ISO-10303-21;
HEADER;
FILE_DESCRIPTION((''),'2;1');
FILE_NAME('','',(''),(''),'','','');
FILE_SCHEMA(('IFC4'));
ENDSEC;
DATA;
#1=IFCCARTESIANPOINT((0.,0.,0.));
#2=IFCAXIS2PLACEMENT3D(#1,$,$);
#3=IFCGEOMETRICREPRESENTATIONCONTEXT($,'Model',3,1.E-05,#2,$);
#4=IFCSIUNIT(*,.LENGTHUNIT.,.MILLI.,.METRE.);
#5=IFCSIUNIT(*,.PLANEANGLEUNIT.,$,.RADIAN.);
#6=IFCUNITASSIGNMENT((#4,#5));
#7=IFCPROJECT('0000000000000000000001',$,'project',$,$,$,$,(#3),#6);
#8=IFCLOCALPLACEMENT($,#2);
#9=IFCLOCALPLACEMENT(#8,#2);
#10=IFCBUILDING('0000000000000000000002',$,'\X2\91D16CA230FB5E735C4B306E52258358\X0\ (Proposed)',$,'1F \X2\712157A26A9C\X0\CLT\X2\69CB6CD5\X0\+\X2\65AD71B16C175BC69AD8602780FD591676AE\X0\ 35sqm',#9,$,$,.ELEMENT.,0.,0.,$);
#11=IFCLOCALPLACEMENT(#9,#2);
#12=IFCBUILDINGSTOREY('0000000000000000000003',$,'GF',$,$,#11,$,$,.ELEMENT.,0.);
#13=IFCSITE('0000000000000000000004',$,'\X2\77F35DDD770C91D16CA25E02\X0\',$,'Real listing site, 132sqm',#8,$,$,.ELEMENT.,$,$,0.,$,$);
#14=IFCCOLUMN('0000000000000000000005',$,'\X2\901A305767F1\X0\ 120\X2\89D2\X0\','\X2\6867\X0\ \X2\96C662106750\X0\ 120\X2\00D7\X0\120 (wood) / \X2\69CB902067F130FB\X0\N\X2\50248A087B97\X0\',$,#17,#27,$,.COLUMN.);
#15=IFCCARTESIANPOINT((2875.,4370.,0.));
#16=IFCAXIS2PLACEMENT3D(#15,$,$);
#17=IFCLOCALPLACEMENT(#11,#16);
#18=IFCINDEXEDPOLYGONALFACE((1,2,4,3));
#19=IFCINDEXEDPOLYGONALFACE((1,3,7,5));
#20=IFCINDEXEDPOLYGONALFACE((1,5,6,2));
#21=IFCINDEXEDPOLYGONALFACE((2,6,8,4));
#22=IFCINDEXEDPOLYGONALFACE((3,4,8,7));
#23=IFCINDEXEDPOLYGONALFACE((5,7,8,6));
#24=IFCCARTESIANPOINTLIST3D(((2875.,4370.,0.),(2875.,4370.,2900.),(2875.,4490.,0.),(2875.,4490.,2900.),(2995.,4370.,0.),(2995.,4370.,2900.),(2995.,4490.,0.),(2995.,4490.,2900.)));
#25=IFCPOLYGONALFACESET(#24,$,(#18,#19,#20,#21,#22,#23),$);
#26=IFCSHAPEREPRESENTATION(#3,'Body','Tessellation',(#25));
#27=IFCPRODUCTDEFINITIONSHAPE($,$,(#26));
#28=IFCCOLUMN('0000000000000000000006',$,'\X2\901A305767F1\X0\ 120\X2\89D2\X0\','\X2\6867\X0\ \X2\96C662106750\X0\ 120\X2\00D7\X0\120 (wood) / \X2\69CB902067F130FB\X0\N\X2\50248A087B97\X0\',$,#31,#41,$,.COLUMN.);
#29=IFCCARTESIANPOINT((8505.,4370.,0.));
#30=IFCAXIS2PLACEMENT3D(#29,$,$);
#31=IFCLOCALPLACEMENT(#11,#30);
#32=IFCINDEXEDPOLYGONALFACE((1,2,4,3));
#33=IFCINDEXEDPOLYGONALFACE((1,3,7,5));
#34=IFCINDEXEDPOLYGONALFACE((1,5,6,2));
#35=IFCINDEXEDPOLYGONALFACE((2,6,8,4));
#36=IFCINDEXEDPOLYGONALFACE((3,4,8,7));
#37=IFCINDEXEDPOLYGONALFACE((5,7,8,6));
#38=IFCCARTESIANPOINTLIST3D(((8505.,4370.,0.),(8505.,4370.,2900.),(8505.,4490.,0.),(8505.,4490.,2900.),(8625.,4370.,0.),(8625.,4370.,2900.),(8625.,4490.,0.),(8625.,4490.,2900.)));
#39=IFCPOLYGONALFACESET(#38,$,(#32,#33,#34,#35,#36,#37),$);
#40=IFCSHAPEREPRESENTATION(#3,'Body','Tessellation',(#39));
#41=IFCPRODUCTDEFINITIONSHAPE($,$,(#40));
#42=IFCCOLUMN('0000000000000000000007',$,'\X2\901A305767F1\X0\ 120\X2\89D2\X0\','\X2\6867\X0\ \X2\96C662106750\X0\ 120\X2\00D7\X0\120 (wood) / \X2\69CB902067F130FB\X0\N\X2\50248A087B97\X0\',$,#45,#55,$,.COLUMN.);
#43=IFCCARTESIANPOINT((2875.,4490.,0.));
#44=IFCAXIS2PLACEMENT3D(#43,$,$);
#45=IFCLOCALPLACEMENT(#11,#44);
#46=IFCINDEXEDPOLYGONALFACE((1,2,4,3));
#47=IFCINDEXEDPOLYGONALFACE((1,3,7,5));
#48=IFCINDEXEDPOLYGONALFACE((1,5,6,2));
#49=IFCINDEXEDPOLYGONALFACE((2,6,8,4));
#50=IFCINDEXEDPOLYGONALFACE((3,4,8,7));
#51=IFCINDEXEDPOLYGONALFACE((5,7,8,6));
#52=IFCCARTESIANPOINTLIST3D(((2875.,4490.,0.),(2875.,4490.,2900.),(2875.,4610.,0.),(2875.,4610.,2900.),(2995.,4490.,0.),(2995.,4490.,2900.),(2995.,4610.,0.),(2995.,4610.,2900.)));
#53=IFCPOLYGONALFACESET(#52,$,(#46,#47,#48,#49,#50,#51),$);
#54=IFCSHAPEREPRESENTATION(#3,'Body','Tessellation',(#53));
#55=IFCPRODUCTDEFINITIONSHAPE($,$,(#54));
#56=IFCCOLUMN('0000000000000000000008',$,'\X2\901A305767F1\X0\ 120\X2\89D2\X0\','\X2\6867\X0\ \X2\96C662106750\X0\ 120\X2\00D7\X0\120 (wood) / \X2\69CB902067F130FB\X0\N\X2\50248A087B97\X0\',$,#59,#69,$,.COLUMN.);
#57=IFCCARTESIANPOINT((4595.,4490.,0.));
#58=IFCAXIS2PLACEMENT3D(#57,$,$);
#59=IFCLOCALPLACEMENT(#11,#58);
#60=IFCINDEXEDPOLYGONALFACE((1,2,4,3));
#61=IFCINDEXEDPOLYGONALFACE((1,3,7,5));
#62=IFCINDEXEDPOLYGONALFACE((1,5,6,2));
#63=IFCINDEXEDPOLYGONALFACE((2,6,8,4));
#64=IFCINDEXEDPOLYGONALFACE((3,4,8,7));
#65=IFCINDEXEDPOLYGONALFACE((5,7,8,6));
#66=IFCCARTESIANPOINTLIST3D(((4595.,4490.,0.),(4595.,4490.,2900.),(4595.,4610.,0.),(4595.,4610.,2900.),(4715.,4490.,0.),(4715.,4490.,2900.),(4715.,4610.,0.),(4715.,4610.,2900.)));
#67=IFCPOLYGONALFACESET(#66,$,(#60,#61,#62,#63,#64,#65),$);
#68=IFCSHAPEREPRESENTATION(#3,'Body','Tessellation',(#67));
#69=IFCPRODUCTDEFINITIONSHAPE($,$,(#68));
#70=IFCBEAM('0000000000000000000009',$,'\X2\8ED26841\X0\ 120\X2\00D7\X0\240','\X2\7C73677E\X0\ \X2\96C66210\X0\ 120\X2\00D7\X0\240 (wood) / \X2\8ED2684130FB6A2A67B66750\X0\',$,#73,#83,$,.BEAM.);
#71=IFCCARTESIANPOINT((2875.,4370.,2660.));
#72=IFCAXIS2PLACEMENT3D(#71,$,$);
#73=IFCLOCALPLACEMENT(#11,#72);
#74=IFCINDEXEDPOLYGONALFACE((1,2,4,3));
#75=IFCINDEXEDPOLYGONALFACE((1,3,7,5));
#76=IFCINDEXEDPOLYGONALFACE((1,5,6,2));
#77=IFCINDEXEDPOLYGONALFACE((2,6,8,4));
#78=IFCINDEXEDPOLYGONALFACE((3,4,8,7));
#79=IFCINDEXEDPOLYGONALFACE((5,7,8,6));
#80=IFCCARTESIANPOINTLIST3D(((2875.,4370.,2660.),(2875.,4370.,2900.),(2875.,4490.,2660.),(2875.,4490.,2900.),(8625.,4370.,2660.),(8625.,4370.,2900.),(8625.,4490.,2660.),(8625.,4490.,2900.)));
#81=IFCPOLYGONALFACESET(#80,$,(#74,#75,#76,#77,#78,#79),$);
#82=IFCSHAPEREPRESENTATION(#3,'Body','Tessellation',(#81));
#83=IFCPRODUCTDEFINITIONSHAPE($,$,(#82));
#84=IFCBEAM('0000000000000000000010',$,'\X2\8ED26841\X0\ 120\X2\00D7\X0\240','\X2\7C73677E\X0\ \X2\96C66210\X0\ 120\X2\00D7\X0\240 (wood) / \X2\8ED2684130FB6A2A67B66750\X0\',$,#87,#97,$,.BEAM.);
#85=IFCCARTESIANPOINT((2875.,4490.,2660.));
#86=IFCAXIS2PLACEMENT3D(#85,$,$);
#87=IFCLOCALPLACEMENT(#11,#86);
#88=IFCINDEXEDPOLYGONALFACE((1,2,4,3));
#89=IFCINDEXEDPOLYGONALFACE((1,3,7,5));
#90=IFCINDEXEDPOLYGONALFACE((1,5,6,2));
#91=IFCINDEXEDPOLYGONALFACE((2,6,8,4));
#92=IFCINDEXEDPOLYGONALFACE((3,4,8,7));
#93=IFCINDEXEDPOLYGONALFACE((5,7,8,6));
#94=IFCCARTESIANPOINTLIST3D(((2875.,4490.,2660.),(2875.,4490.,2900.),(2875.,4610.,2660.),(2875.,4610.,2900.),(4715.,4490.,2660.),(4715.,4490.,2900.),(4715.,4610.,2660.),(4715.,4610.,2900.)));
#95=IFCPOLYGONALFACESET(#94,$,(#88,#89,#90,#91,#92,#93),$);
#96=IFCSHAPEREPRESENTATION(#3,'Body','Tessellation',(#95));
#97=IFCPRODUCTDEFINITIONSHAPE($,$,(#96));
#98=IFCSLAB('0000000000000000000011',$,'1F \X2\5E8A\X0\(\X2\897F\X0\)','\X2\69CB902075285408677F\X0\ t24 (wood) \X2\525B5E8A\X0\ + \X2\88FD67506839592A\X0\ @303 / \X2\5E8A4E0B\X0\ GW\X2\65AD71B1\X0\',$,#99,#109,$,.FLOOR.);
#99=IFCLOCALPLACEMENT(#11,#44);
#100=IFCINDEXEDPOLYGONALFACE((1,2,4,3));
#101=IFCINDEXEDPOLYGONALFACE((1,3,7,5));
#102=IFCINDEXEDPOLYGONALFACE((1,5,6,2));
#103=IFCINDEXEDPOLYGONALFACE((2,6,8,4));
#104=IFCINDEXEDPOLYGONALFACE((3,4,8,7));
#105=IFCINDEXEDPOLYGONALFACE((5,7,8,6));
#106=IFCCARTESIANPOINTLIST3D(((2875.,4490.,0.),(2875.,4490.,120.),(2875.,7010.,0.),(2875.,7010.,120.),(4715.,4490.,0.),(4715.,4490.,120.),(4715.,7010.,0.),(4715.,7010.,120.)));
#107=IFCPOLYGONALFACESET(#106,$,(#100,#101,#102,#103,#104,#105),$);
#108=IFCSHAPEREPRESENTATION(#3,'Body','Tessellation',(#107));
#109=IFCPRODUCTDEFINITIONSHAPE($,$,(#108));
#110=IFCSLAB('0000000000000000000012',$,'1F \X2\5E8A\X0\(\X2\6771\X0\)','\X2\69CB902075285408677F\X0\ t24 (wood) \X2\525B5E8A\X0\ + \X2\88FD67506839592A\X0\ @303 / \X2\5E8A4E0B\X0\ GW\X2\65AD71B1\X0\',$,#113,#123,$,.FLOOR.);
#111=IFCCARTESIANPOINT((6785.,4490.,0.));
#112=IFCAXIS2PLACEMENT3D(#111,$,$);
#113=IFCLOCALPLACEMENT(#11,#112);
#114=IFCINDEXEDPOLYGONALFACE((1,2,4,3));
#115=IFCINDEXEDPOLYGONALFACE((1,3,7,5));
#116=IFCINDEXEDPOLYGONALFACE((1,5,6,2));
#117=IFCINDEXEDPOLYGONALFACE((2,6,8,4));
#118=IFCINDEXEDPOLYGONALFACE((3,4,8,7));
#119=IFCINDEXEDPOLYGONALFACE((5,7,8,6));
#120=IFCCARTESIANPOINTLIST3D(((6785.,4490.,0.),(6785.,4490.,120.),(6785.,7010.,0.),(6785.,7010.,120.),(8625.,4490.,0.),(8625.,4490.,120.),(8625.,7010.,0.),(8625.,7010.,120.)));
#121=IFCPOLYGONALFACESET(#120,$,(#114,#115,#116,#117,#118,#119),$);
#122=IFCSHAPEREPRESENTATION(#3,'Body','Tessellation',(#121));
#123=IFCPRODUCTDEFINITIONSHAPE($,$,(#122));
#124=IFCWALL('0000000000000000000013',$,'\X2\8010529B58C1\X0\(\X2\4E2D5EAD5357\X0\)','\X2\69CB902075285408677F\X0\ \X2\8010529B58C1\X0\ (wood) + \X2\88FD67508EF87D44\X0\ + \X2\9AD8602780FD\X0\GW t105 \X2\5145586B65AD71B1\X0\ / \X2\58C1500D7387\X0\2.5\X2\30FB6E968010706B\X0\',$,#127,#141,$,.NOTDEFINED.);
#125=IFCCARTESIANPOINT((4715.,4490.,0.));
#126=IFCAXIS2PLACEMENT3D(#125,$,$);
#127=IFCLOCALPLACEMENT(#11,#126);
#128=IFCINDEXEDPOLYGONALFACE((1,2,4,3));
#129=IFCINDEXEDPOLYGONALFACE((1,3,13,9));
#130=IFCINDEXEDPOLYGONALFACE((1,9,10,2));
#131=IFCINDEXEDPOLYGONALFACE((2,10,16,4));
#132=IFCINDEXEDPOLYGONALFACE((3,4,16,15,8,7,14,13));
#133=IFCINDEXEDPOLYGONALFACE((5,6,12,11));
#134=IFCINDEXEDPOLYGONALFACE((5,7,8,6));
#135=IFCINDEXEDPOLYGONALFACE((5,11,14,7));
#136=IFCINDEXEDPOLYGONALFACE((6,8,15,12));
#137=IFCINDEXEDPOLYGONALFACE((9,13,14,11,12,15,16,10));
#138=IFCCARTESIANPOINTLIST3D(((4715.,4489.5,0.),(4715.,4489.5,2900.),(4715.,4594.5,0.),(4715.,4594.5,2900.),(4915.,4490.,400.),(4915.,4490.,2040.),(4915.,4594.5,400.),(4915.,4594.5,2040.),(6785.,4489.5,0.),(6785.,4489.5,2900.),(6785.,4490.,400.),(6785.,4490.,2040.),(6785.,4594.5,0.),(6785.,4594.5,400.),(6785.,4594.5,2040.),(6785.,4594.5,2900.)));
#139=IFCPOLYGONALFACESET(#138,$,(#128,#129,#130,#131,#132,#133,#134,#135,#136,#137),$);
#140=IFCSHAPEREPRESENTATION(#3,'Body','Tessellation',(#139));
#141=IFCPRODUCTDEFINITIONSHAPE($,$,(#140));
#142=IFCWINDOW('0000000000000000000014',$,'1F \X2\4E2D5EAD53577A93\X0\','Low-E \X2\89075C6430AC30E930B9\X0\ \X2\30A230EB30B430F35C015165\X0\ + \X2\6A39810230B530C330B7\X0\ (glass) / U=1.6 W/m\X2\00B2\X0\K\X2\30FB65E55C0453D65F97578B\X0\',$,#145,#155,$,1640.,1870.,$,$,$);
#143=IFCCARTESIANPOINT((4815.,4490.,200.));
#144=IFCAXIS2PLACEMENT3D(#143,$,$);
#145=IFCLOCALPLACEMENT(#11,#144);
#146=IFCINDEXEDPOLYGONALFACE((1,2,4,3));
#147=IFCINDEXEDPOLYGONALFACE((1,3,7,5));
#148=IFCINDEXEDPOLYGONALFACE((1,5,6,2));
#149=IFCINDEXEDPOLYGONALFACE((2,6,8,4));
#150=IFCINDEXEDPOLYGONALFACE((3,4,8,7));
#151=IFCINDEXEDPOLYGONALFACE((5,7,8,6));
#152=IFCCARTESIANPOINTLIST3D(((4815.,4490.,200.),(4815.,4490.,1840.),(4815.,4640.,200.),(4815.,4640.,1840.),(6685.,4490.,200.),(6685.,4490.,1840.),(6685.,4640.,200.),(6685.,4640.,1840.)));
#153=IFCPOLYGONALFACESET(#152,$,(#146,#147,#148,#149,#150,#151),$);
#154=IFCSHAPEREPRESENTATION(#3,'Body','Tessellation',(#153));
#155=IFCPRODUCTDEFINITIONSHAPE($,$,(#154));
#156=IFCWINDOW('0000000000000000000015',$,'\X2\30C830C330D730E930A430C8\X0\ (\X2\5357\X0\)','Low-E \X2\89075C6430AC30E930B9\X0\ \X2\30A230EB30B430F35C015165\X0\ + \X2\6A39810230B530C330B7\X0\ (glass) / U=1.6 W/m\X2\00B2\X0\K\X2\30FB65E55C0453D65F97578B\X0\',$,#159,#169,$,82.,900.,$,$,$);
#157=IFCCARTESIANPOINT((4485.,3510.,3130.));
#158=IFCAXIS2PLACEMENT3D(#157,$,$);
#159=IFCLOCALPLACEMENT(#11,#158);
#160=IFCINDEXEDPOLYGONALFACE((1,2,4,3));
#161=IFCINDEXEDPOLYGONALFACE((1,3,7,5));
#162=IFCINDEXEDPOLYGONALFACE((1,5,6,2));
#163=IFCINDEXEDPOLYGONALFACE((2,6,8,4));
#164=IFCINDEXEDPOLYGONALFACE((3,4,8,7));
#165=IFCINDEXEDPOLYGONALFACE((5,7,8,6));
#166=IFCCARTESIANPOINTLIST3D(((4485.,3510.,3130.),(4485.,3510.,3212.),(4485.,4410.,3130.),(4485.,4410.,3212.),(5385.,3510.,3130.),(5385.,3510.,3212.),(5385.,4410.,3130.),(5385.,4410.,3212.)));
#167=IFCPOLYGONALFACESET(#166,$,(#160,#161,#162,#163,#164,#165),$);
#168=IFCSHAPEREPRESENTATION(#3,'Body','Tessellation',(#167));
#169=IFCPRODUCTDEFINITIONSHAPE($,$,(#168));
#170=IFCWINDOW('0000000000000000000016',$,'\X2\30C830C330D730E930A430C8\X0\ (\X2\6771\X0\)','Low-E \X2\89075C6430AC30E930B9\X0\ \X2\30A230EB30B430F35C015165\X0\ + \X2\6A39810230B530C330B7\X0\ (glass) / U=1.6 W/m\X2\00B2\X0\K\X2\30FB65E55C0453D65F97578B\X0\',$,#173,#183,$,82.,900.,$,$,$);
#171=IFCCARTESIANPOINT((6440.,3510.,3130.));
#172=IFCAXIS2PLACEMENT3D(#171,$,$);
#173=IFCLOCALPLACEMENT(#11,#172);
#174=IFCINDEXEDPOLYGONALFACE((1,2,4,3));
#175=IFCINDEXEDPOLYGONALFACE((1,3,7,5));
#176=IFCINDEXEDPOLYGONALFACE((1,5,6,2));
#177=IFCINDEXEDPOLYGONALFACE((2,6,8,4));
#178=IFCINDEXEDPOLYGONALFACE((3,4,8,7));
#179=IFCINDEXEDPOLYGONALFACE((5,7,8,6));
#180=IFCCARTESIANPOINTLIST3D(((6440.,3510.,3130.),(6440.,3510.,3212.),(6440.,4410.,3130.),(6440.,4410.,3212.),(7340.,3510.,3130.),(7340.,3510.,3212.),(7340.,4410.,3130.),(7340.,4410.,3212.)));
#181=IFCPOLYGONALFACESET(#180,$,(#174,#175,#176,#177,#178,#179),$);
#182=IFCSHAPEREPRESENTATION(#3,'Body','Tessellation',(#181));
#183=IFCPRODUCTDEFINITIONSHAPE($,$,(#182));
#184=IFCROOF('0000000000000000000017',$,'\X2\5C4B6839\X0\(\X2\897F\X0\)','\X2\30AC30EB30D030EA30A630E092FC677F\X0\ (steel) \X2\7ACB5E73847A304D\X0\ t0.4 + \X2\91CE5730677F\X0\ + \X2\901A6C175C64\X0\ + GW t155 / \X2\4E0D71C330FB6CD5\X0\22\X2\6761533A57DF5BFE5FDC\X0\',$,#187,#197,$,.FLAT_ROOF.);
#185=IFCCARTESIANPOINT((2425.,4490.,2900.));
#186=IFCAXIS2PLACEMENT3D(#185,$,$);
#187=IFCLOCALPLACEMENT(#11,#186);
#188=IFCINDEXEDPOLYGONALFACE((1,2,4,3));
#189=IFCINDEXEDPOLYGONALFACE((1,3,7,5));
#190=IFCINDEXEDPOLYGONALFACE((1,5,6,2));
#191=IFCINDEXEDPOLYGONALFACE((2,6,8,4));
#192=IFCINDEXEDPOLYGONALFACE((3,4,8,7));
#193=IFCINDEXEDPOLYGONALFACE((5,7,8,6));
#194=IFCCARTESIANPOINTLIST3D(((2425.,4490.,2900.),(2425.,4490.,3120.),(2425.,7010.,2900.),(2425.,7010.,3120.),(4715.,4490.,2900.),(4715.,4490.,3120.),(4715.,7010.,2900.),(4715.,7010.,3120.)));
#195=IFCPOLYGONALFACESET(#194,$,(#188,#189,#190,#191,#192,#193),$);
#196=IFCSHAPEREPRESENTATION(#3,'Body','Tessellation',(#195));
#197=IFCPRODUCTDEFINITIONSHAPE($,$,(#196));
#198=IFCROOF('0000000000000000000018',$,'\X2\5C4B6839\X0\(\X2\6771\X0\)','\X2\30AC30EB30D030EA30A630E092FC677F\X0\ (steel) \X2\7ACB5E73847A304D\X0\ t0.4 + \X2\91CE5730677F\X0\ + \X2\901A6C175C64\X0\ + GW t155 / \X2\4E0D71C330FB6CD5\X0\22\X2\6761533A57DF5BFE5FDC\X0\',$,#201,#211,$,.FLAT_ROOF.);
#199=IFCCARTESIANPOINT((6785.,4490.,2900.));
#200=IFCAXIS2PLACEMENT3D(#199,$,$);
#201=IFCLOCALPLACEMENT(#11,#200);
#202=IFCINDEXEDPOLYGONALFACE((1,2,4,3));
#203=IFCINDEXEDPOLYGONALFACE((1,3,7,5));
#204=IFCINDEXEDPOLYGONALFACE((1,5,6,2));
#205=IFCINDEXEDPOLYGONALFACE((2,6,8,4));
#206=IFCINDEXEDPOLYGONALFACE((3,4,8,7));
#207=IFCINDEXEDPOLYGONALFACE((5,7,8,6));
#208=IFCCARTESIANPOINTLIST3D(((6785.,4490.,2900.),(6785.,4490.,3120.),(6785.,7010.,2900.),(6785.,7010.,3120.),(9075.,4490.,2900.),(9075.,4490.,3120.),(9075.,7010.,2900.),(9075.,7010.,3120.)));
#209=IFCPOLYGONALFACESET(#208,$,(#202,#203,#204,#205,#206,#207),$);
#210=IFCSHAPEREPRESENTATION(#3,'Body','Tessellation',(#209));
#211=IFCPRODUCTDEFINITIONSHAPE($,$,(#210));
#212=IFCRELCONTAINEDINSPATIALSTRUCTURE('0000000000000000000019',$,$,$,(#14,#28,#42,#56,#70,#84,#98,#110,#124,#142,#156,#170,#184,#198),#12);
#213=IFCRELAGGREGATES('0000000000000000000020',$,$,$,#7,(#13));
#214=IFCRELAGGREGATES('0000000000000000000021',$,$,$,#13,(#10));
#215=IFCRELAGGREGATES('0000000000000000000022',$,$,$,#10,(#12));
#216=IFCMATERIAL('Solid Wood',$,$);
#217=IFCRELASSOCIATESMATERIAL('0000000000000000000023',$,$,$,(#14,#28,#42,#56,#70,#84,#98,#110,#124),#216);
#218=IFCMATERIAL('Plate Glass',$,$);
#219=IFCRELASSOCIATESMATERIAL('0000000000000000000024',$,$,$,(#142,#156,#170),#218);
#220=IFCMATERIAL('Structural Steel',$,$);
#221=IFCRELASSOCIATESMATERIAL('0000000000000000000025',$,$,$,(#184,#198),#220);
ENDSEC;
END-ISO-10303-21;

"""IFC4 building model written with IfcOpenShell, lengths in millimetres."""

from ifc_helpers import new_model, si_unit, frame, frame_2d, origin, place, context, project, spatial, rectangle, extrude, material, element, fill, save


model = new_model("IFC4")

# Units and contexts
model_context = context("Model", 3, precision=1e-05, world=origin())
ifc_project = project(units=[si_unit("LENGTHUNIT", "METRE", prefix="MILLI"), si_unit("PLANEANGLEUNIT", "RADIAN")], contexts=[model_context])

# Site, building, storey
site_placement = place(None, origin())
site = spatial("IfcSite", under=ifc_project, at=site_placement, Name="石川県金沢市", ObjectType="Real listing site, 132sqm", CompositionType="ELEMENT", RefElevation=0.0)
building_placement = place(site_placement, origin())
building = spatial("IfcBuilding", under=site, at=building_placement, Name="金沢・平屋の別荘 (Proposed)", ObjectType="1F 無垢檜CLT構法+断熱気密高性能外皮 35sqm", CompositionType="ELEMENT", ElevationOfRefHeight=0.0, ElevationOfTerrain=0.0)
storey_placement = place(building_placement, origin())
storey = spatial("IfcBuildingStorey", under=building, at=storey_placement, Name="GF", CompositionType="ELEMENT", Elevation=0.0)

# Columns
ifc_material_1 = material(Name="Solid Wood")
column_1_placement = place(storey_placement, frame((2875.0, 4370.0, 0.0)))
element("IfcColumn", 1, at=column_1_placement, inside=storey, material=ifc_material_1, Name="通し柱 120角", Description="桧 集成材 120×120 (wood) / 構造柱・N値計算", PredefinedType="COLUMN", context=model_context, shape_type="SweptSolid", body=[
    extrude(rectangle(XDim=120.0, YDim=120.0, at=frame_2d((60.0, 60.0))), frame((2875.0, 4370.0, 0.0)), (0.0, 0.0, 1.0), 2900.0),
])
column_2_placement = place(storey_placement, frame((8505.0, 4370.0, 0.0)))
element("IfcColumn", 2, at=column_2_placement, inside=storey, material=ifc_material_1, Name="通し柱 120角", Description="桧 集成材 120×120 (wood) / 構造柱・N値計算", PredefinedType="COLUMN", context=model_context, shape_type="SweptSolid", body=[
    extrude(rectangle(XDim=120.0, YDim=120.0, at=frame_2d((60.0, 60.0))), frame((8505.0, 4370.0, 0.0)), (0.0, 0.0, 1.0), 2900.0),
])
column_3_placement = place(storey_placement, frame((2875.0, 4490.0, 0.0)))
element("IfcColumn", 3, at=column_3_placement, inside=storey, material=ifc_material_1, Name="通し柱 120角", Description="桧 集成材 120×120 (wood) / 構造柱・N値計算", PredefinedType="COLUMN", context=model_context, shape_type="SweptSolid", body=[
    extrude(rectangle(XDim=120.0, YDim=120.0, at=frame_2d((60.0, 60.0))), frame((2875.0, 4490.0, 0.0)), (0.0, 0.0, 1.0), 2900.0),
])
column_4_placement = place(storey_placement, frame((4595.0, 4490.0, 0.0)))
element("IfcColumn", 4, at=column_4_placement, inside=storey, material=ifc_material_1, Name="通し柱 120角", Description="桧 集成材 120×120 (wood) / 構造柱・N値計算", PredefinedType="COLUMN", context=model_context, shape_type="SweptSolid", body=[
    extrude(rectangle(XDim=120.0, YDim=120.0, at=frame_2d((60.0, 60.0))), frame((4595.0, 4490.0, 0.0)), (0.0, 0.0, 1.0), 2900.0),
])

# Beams
beam_1_placement = place(storey_placement, frame((2875.0, 4370.0, 2660.0)))
element("IfcBeam", 5, at=beam_1_placement, inside=storey, material=ifc_material_1, Name="軒桁 120×240", Description="米松 集成 120×240 (wood) / 軒桁・横架材", PredefinedType="BEAM", context=model_context, shape_type="SweptSolid", body=[
    extrude(rectangle(XDim=5750.0, YDim=120.0, at=frame_2d((2875.0, 60.0))), frame((2875.0, 4370.0, 2660.0)), (0.0, 0.0, 1.0), 240.0),
])
beam_2_placement = place(storey_placement, frame((2875.0, 4490.0, 2660.0)))
element("IfcBeam", 6, at=beam_2_placement, inside=storey, material=ifc_material_1, Name="軒桁 120×240", Description="米松 集成 120×240 (wood) / 軒桁・横架材", PredefinedType="BEAM", context=model_context, shape_type="SweptSolid", body=[
    extrude(rectangle(XDim=1840.0, YDim=120.0, at=frame_2d((920.0, 60.0))), frame((2875.0, 4490.0, 2660.0)), (0.0, 0.0, 1.0), 240.0),
])

# Slabs
slab_1_placement = place(storey_placement, frame((2875.0, 4490.0, 0.0)))
element("IfcSlab", 7, at=slab_1_placement, inside=storey, material=ifc_material_1, Name="1F 床(西)", Description="構造用合板 t24 (wood) 剛床 + 製材根太 @303 / 床下 GW断熱", PredefinedType="FLOOR", context=model_context, shape_type="SweptSolid", body=[
    extrude(rectangle(XDim=1840.0, YDim=2520.0, at=frame_2d((920.0, 1260.0))), frame((2875.0, 4490.0, 0.0)), (0.0, 0.0, 1.0), 120.0),
])
slab_2_placement = place(storey_placement, frame((6785.0, 4490.0, 0.0)))
element("IfcSlab", 8, at=slab_2_placement, inside=storey, material=ifc_material_1, Name="1F 床(東)", Description="構造用合板 t24 (wood) 剛床 + 製材根太 @303 / 床下 GW断熱", PredefinedType="FLOOR", context=model_context, shape_type="SweptSolid", body=[
    extrude(rectangle(XDim=1840.0, YDim=2520.0, at=frame_2d((920.0, 1260.0))), frame((6785.0, 4490.0, 0.0)), (0.0, 0.0, 1.0), 120.0),
])

# Wall, opening, window
wall_1_placement = place(storey_placement, frame((4715.0, 4490.0, 0.0)))
wall_1 = element("IfcWall", 9, at=wall_1_placement, inside=storey, material=ifc_material_1, Name="耐力壁(中庭南)", Description="構造用合板 耐力壁 (wood) + 製材軸組 + 高性能GW t105 充填断熱 / 壁倍率2.5・準耐火", PredefinedType="NOTDEFINED", context=model_context, shape_type="SweptSolid", body=[
    extrude(rectangle(XDim=2070.0, YDim=105.0, at=frame_2d((1035.0, 52.0))), frame((4715.0, 4490.0, 0.0)), (0.0, 0.0, 1.0), 2900.0),
])
opening_placement = place(storey_placement, frame((4815.0, 4490.0, 200.0)))
opening = element("IfcOpeningElement", 10, at=opening_placement, cuts=wall_1, PredefinedType="NOTDEFINED", context=model_context, shape_type="SweptSolid", body=[
    extrude(rectangle(XDim=1870.0, YDim=150.0, at=frame_2d((935.0, 75.0))), frame((4815.0, 4490.0, 200.0)), (0.0, 0.0, 1.0), 1640.0),
])
ifc_material_2 = material(Name="Plate Glass")
window_1_placement = place(storey_placement, frame((4815.0, 4490.0, 200.0)))
window_1 = element("IfcWindow", 11, at=window_1_placement, inside=storey, material=ifc_material_2, Name="1F 中庭南窓", Description="Low-E 複層ガラス アルゴン封入 + 樹脂サッシ (glass) / U=1.6 W/m²K・日射取得型", OverallHeight=1640.0, OverallWidth=1870.0, context=model_context, shape_type="SweptSolid", body=[
    extrude(rectangle(XDim=1870.0, YDim=150.0, at=frame_2d((935.0, 75.0))), frame((4815.0, 4490.0, 200.0)), (0.0, 0.0, 1.0), 1640.0),
])
fill(opening, window_1)

# Windows
window_2_placement = place(storey_placement, frame((4485.0, 3510.0, 3130.0)))
element("IfcWindow", 12, at=window_2_placement, inside=storey, material=ifc_material_2, Name="トップライト (南)", Description="Low-E 複層ガラス アルゴン封入 + 樹脂サッシ (glass) / U=1.6 W/m²K・日射取得型", OverallHeight=82.0, OverallWidth=900.0, context=model_context, shape_type="SweptSolid", body=[
    extrude(rectangle(XDim=900.0, YDim=900.0, at=frame_2d((450.0, 450.0))), frame((4485.0, 3510.0, 3130.0)), (0.0, 0.0, 1.0), 82.0),
])
window_3_placement = place(storey_placement, frame((6440.0, 3510.0, 3130.0)))
element("IfcWindow", 13, at=window_3_placement, inside=storey, material=ifc_material_2, Name="トップライト (東)", Description="Low-E 複層ガラス アルゴン封入 + 樹脂サッシ (glass) / U=1.6 W/m²K・日射取得型", OverallHeight=82.0, OverallWidth=900.0, context=model_context, shape_type="SweptSolid", body=[
    extrude(rectangle(XDim=900.0, YDim=900.0, at=frame_2d((450.0, 450.0))), frame((6440.0, 3510.0, 3130.0)), (0.0, 0.0, 1.0), 82.0),
])

# Roofs
ifc_material_3 = material(Name="Structural Steel")
roof_1_placement = place(storey_placement, frame((2425.0, 4490.0, 2900.0)))
element("IfcRoof", 14, at=roof_1_placement, inside=storey, material=ifc_material_3, Name="屋根(西)", Description="ガルバリウム鋼板 (steel) 立平葺き t0.4 + 野地板 + 通気層 + GW t155 / 不燃・法22条区域対応", PredefinedType="FLAT_ROOF", context=model_context, shape_type="SweptSolid", body=[
    extrude(rectangle(XDim=2290.0, YDim=2520.0, at=frame_2d((1145.0, 1260.0))), frame((2425.0, 4490.0, 2900.0)), (0.0, 0.0, 1.0), 220.0),
])
roof_2_placement = place(storey_placement, frame((6785.0, 4490.0, 2900.0)))
element("IfcRoof", 15, at=roof_2_placement, inside=storey, material=ifc_material_3, Name="屋根(東)", Description="ガルバリウム鋼板 (steel) 立平葺き t0.4 + 野地板 + 通気層 + GW t155 / 不燃・法22条区域対応", PredefinedType="FLAT_ROOF", context=model_context, shape_type="SweptSolid", body=[
    extrude(rectangle(XDim=2290.0, YDim=2520.0, at=frame_2d((1145.0, 1260.0))), frame((6785.0, 4490.0, 2900.0)), (0.0, 0.0, 1.0), 220.0),
])

save(model, "model.ifc")
